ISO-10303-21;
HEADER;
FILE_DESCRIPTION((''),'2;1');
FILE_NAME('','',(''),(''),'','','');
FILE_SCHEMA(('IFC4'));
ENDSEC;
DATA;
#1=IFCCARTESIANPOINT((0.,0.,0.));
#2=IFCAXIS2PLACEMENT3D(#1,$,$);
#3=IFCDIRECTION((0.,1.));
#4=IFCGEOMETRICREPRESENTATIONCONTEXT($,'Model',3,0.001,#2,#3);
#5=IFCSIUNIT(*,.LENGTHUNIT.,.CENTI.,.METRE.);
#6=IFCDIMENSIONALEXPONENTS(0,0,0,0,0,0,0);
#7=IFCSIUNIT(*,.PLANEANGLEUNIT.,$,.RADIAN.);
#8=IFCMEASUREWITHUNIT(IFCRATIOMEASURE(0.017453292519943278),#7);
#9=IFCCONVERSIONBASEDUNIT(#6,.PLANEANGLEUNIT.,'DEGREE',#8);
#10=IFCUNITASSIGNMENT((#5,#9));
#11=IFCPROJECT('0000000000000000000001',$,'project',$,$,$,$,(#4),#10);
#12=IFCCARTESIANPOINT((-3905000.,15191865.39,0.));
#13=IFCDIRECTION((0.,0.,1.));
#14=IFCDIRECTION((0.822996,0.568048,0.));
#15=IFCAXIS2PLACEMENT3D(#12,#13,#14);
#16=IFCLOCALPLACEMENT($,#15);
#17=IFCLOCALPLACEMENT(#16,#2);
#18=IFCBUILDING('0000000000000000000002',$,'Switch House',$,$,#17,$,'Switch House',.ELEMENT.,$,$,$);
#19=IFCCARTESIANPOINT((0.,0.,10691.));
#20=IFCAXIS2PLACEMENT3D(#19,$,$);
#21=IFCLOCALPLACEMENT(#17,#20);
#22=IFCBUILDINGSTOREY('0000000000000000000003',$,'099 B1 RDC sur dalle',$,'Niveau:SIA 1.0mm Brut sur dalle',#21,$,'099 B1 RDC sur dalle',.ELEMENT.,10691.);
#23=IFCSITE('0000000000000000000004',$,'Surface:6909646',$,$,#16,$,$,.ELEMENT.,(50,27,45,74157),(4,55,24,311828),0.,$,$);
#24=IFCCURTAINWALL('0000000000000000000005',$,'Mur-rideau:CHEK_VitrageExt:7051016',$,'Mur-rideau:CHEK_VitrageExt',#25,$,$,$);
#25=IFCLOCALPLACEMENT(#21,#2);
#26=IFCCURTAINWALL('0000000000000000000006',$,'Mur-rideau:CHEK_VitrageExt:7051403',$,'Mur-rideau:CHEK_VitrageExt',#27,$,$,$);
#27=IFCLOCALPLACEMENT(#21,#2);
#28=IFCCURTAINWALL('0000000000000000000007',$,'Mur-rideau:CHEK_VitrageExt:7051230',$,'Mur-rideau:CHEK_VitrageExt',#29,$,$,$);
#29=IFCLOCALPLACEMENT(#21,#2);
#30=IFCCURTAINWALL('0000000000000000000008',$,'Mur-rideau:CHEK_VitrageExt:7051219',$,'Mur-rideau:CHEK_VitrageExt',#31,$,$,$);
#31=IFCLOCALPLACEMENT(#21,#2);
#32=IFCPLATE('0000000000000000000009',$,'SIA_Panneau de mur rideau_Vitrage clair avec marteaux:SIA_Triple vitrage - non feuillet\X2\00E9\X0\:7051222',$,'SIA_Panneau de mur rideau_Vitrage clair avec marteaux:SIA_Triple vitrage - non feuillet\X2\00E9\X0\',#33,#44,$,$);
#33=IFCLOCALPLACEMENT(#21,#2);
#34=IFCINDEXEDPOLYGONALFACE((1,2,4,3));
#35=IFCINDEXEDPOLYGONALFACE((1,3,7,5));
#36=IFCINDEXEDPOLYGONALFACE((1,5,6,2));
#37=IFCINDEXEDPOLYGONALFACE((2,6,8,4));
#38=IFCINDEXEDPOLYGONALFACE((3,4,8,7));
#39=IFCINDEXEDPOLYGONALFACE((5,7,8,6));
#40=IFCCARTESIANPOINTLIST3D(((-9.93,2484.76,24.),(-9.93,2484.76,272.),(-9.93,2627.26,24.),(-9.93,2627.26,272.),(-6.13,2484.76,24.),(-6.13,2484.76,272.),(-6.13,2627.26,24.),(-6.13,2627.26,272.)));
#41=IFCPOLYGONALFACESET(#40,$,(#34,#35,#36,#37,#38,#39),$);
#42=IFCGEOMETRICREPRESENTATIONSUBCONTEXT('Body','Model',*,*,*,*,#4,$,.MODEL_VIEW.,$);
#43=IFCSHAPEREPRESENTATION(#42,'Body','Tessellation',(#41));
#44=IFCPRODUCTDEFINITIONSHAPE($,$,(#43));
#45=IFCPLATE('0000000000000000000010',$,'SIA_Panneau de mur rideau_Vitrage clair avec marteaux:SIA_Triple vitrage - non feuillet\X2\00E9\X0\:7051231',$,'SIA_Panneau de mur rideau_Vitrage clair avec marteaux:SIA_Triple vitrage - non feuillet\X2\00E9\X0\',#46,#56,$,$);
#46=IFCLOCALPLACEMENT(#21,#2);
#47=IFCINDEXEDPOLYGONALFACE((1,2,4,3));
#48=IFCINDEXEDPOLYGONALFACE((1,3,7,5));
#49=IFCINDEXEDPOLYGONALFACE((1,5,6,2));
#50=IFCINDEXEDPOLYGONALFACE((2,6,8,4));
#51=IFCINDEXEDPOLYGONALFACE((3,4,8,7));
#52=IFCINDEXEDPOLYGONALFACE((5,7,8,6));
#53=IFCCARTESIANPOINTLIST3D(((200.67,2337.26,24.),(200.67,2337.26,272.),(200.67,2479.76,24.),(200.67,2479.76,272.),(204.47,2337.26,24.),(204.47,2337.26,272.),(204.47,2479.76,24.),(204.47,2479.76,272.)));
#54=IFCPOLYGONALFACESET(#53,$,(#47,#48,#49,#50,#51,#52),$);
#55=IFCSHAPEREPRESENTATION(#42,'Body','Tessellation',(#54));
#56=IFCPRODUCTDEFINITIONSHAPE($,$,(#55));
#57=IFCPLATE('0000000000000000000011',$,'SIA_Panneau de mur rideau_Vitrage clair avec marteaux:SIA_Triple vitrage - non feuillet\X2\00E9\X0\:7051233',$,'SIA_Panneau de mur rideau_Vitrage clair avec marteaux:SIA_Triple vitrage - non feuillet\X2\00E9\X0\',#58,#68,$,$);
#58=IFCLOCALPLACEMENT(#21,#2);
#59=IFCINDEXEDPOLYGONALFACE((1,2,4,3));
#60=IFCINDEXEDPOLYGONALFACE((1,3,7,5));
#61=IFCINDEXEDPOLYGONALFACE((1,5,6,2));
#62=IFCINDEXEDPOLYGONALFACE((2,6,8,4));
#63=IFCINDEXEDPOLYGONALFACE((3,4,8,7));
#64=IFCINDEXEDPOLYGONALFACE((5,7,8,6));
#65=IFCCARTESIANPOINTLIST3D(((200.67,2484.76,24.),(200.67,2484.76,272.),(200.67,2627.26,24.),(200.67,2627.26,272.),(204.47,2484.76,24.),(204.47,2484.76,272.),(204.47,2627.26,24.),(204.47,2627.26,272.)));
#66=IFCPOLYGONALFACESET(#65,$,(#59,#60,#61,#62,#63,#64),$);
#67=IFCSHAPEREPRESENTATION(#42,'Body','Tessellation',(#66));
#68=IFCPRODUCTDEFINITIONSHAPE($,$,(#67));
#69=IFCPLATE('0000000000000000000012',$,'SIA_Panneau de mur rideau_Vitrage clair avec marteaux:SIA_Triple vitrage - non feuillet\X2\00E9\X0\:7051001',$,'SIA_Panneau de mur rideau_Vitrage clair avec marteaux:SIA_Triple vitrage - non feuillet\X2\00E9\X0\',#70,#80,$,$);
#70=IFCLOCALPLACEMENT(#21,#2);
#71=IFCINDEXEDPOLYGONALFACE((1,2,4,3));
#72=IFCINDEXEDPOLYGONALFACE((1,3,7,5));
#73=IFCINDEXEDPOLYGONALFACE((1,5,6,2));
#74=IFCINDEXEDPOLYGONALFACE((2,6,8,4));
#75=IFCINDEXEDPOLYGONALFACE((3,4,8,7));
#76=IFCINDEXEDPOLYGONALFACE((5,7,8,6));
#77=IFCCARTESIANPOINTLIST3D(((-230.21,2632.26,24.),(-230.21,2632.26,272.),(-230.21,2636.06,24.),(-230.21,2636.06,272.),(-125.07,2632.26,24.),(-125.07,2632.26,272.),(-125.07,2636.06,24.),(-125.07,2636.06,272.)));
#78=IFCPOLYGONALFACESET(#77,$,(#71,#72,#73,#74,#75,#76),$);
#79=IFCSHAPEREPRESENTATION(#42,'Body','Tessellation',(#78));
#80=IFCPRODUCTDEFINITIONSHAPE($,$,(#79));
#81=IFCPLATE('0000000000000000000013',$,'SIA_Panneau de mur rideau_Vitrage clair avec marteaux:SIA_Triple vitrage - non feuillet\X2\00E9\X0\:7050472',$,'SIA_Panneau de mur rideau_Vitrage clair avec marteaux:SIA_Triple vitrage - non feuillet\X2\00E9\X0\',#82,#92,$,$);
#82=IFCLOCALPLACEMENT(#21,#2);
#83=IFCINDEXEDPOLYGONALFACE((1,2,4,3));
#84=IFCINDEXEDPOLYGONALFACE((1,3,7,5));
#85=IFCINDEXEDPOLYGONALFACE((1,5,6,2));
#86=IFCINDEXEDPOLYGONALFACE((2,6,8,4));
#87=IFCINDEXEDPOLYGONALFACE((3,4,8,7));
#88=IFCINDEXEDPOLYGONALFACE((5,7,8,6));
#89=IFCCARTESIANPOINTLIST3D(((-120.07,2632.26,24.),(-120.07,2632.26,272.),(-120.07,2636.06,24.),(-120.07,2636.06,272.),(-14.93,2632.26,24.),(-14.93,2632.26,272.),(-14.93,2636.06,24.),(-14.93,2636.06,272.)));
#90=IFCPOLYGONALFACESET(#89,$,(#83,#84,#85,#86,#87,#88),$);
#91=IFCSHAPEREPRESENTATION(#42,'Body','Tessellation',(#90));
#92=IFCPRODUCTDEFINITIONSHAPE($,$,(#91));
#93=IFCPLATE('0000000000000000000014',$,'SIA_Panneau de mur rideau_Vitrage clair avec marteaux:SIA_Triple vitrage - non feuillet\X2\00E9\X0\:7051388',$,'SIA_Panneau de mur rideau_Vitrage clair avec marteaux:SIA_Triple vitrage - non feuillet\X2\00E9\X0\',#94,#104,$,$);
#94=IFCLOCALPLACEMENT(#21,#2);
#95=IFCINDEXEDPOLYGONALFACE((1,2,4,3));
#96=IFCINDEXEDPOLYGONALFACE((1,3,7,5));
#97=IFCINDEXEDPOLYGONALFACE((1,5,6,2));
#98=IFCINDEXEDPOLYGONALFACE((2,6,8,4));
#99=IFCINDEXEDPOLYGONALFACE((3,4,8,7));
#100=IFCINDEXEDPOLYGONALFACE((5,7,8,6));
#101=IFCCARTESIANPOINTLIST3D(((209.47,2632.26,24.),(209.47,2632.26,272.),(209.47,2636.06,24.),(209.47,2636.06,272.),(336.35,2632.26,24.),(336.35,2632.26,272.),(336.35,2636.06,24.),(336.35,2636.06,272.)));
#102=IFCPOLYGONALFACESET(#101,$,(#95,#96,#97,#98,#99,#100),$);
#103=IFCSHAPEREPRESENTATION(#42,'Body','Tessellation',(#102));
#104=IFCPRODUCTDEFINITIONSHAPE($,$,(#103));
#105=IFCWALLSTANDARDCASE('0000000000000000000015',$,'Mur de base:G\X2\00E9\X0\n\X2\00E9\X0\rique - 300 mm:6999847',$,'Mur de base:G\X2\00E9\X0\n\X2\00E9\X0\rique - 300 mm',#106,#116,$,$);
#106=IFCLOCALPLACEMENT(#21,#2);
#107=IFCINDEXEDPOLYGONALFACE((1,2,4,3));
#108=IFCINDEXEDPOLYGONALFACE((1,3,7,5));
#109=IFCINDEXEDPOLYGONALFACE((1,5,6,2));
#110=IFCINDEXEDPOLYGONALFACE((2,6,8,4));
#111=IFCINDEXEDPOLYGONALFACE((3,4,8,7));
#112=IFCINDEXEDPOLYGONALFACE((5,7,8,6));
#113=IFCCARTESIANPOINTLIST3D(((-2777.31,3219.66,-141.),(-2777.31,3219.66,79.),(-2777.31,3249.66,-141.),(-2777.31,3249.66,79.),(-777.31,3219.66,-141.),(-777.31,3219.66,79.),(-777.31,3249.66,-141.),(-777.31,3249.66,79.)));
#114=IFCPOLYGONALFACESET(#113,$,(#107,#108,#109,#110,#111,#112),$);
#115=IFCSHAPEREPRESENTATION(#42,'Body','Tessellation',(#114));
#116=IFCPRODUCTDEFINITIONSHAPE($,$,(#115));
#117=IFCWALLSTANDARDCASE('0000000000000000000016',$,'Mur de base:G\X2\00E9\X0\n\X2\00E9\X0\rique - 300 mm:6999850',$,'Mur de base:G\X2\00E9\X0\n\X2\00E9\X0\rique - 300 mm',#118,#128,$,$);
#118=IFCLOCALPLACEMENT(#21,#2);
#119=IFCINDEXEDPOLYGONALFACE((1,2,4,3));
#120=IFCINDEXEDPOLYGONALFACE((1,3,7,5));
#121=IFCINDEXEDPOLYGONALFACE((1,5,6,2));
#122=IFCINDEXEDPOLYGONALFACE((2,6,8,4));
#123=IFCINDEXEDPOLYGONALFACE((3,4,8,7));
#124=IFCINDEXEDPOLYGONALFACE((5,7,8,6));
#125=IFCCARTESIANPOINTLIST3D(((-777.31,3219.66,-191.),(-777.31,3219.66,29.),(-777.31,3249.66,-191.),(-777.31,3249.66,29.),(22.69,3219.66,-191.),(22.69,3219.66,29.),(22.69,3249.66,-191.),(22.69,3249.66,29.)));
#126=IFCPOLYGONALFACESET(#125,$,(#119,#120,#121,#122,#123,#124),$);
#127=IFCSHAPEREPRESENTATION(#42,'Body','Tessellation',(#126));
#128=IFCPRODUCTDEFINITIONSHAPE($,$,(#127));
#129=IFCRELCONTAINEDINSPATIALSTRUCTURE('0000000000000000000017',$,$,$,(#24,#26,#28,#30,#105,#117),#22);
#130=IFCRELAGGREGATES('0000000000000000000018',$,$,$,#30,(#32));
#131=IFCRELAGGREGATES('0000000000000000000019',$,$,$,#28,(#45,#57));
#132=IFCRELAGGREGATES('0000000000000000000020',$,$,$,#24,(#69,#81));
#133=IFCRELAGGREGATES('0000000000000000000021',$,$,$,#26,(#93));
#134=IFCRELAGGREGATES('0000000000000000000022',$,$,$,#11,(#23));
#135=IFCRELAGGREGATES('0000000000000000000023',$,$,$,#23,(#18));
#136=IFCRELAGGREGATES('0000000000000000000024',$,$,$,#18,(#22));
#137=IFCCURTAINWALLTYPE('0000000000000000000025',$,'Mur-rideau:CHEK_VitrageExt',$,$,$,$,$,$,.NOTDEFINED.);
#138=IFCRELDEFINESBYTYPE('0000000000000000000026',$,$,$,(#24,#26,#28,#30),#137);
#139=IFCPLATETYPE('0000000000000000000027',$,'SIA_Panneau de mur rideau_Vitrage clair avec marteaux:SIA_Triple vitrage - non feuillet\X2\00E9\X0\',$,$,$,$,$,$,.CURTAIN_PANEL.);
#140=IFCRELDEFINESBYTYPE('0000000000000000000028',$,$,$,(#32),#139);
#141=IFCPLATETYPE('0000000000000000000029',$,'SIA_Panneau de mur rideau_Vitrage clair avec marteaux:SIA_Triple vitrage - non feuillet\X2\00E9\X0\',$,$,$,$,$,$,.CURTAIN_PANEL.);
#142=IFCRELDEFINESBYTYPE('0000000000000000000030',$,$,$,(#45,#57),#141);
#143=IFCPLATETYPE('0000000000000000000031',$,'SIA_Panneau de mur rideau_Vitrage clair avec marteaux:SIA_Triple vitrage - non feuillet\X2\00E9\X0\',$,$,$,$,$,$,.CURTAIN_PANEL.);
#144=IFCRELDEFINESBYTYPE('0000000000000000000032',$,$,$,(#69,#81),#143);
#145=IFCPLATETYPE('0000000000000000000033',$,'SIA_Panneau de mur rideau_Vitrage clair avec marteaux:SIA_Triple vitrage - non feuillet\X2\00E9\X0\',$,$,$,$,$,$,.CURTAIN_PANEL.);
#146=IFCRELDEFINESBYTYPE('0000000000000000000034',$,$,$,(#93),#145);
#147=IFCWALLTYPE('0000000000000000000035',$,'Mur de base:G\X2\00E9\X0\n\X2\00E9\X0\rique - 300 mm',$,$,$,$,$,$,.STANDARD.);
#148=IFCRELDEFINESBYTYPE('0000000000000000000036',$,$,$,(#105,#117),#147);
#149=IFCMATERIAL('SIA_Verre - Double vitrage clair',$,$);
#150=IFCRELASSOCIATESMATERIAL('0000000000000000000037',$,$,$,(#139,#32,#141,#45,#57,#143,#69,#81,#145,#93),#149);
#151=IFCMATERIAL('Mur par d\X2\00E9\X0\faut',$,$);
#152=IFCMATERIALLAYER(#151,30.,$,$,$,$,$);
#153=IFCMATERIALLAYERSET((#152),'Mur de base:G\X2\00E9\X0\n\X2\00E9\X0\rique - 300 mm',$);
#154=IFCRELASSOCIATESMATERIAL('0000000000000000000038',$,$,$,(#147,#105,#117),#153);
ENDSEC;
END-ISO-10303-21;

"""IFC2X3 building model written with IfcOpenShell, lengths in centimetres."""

from ifc_helpers import new_model, entity, si_unit, converted_unit, direction, frame, frame_2d, origin, origin_2d_with_axis, place, context, subcontext, project, spatial, rectangle, extrude, source, transform, mapped, material, layer, layer_set, layer_usage, type_object, type_shapes, element, aggregate, save


model = new_model("IFC2X3")

# Units and contexts
model_context = context("Model", 3, precision=0.001, world=origin(), true_north=direction((0.0, 1.0)))
body_context = subcontext(model_context, "Body", "Model", "MODEL_VIEW")
ifc_project = project(units=[si_unit("LENGTHUNIT", "METRE", prefix="CENTI"), converted_unit("PLANEANGLEUNIT", "DEGREE", entity("IfcRatioMeasure", 0.017453292519943278), si_unit("PLANEANGLEUNIT", "RADIAN"), dimensions=[0, 0, 0, 0, 0, 0, 0])], contexts=[model_context])

# Site, building, storey
site_placement = place(None, frame((-3905000.0, 15191865.39, 0.0), z_axis=(0.0, 0.0, 1.0), x_axis=(0.822996, 0.568048, 0.0)))
site = spatial("IfcSite", under=ifc_project, at=site_placement, Name="Surface:6909646", CompositionType="ELEMENT", RefLatitude=(50, 27, 45, 74157), RefLongitude=(4, 55, 24, 311828), RefElevation=0.0)
building_placement = place(site_placement, origin())
building = spatial("IfcBuilding", under=site, at=building_placement, Name="Switch House", LongName="Switch House", CompositionType="ELEMENT")
storey_placement = place(building_placement, frame((0.0, 0.0, 10691.0)))
storey = spatial("IfcBuildingStorey", under=building, at=storey_placement, Name="099 B1 RDC sur dalle", ObjectType="Niveau:SIA 1.0mm Brut sur dalle", LongName="099 B1 RDC sur dalle", CompositionType="ELEMENT", Elevation=10691.0)

# Curtain walls
curtain_wall_type = type_object("IfcCurtainWallType", Name="Mur-rideau:CHEK_VitrageExt", PredefinedType="NOTDEFINED")
curtain_wall_1_placement = place(storey_placement, frame((0.0, 0.0, -10691.0)))
curtain_wall_1 = element("IfcCurtainWall", 1, at=curtain_wall_1_placement, inside=storey, type_object=curtain_wall_type, Name="Mur-rideau:CHEK_VitrageExt:7051016", ObjectType="Mur-rideau:CHEK_VitrageExt")
curtain_wall_2_placement = place(storey_placement, frame((0.0, 0.0, -10691.0)))
curtain_wall_2 = element("IfcCurtainWall", 2, at=curtain_wall_2_placement, inside=storey, type_object=curtain_wall_type, Name="Mur-rideau:CHEK_VitrageExt:7051403", ObjectType="Mur-rideau:CHEK_VitrageExt")

# Curtain wall
curtain_wall_3_placement = place(storey_placement, frame((0.0, 0.0, -10691.0)))
curtain_wall_3 = element("IfcCurtainWall", 3, at=curtain_wall_3_placement, inside=storey, type_object=curtain_wall_type, Name="Mur-rideau:CHEK_VitrageExt:7051230", ObjectType="Mur-rideau:CHEK_VitrageExt")

# Curtain wall
curtain_wall_4_placement = place(storey_placement, frame((0.0, 0.0, -10691.0)))
curtain_wall_4 = element("IfcCurtainWall", 4, at=curtain_wall_4_placement, inside=storey, type_object=curtain_wall_type, Name="Mur-rideau:CHEK_VitrageExt:7051219", ObjectType="Mur-rideau:CHEK_VitrageExt")

# Plates
ifc_material_1 = material(Name="SIA_Verre - Double vitrage clair")
plate_type_1 = type_object("IfcPlateType", Name="SIA_Panneau de mur rideau_Vitrage clair avec marteaux:SIA_Triple vitrage - non feuilleté", PredefinedType="CURTAIN_PANEL", material=ifc_material_1)
shared_shape_1 = source(origin(), body_context, "Body", "SweptSolid", [
    extrude(rectangle(XDim=3.8, YDim=142.5, at=origin_2d_with_axis()), frame((0.0, -1.9, 0.0), z_axis=(0.0, 0.0, 1.0), x_axis=(0.0, 1.0, 0.0)), (0.0, 0.0, 1.0), 248.0),
])
type_shapes(plate_type_1, [shared_shape_1])
plate_1_placement = place(curtain_wall_4_placement, frame((-9.93, 2556.01, 10715.0), z_axis=(0.0, 0.0, 1.0), x_axis=(0.0, 1.0, 0.0)))
plate_1 = element("IfcPlate", 5, at=plate_1_placement, type_object=plate_type_1, material=ifc_material_1, Name="SIA_Panneau de mur rideau_Vitrage clair avec marteaux:SIA_Triple vitrage - non feuilleté:7051222", ObjectType="SIA_Panneau de mur rideau_Vitrage clair avec marteaux:SIA_Triple vitrage - non feuilleté", context=body_context, shape_type="MappedRepresentation", body=[
    mapped(shared_shape_1, transform((0.0, 0.0, 0.0), scale=1.0)),
])
aggregate(curtain_wall_4, [plate_1])
plate_type_2 = type_object("IfcPlateType", Name="SIA_Panneau de mur rideau_Vitrage clair avec marteaux:SIA_Triple vitrage - non feuilleté", PredefinedType="CURTAIN_PANEL", material=ifc_material_1)
shared_shape_2 = source(origin(), body_context, "Body", "SweptSolid", [
    extrude(rectangle(XDim=142.5, YDim=3.8, at=origin_2d_with_axis()), frame((0.0, 1.9, 0.0), z_axis=(0.0, 0.0, 1.0), x_axis=(-1.0, 0.0, 0.0)), (0.0, 0.0, 1.0), 248.0),
])
type_shapes(plate_type_2, [shared_shape_2])
plate_2_placement = place(curtain_wall_3_placement, frame((204.47, 2408.51, 10715.0), z_axis=(0.0, 0.0, 1.0), x_axis=(0.0, 1.0, 0.0)))
plate_2 = element("IfcPlate", 6, at=plate_2_placement, type_object=plate_type_2, material=ifc_material_1, Name="SIA_Panneau de mur rideau_Vitrage clair avec marteaux:SIA_Triple vitrage - non feuilleté:7051231", ObjectType="SIA_Panneau de mur rideau_Vitrage clair avec marteaux:SIA_Triple vitrage - non feuilleté", context=body_context, shape_type="MappedRepresentation", body=[
    mapped(shared_shape_2, transform((0.0, 0.0, 0.0), scale=1.0)),
])
plate_3_placement = place(curtain_wall_3_placement, frame((204.47, 2556.01, 10715.0), z_axis=(0.0, 0.0, 1.0), x_axis=(0.0, 1.0, 0.0)))
plate_3 = element("IfcPlate", 7, at=plate_3_placement, type_object=plate_type_2, material=ifc_material_1, Name="SIA_Panneau de mur rideau_Vitrage clair avec marteaux:SIA_Triple vitrage - non feuilleté:7051233", ObjectType="SIA_Panneau de mur rideau_Vitrage clair avec marteaux:SIA_Triple vitrage - non feuilleté", context=body_context, shape_type="MappedRepresentation", body=[
    mapped(shared_shape_2, transform((0.0, 0.0, 0.0), scale=1.0)),
])
aggregate(curtain_wall_3, [plate_2, plate_3])
plate_type_3 = type_object("IfcPlateType", Name="SIA_Panneau de mur rideau_Vitrage clair avec marteaux:SIA_Triple vitrage - non feuilleté", PredefinedType="CURTAIN_PANEL", material=ifc_material_1)
shared_shape_3 = source(origin(), body_context, "Body", "SweptSolid", [
    extrude(rectangle(XDim=105.14, YDim=3.8, at=origin_2d_with_axis()), frame((0.0, 1.9, 0.0), z_axis=(0.0, 0.0, 1.0), x_axis=(-1.0, 0.0, 0.0)), (0.0, 0.0, 1.0), 248.0),
])
type_shapes(plate_type_3, [shared_shape_3])
plate_4_placement = place(curtain_wall_1_placement, frame((-177.64, 2632.26, 10715.0)))
plate_4 = element("IfcPlate", 8, at=plate_4_placement, type_object=plate_type_3, material=ifc_material_1, Name="SIA_Panneau de mur rideau_Vitrage clair avec marteaux:SIA_Triple vitrage - non feuilleté:7051001", ObjectType="SIA_Panneau de mur rideau_Vitrage clair avec marteaux:SIA_Triple vitrage - non feuilleté", context=body_context, shape_type="MappedRepresentation", body=[
    mapped(shared_shape_3, transform((0.0, 0.0, 0.0), scale=1.0)),
])
plate_5_placement = place(curtain_wall_1_placement, frame((-67.5, 2632.26, 10715.0)))
plate_5 = element("IfcPlate", 9, at=plate_5_placement, type_object=plate_type_3, material=ifc_material_1, Name="SIA_Panneau de mur rideau_Vitrage clair avec marteaux:SIA_Triple vitrage - non feuilleté:7050472", ObjectType="SIA_Panneau de mur rideau_Vitrage clair avec marteaux:SIA_Triple vitrage - non feuilleté", context=body_context, shape_type="MappedRepresentation", body=[
    mapped(shared_shape_3, transform((0.0, 0.0, 0.0), scale=1.0)),
])
aggregate(curtain_wall_1, [plate_4, plate_5])
plate_type_4 = type_object("IfcPlateType", Name="SIA_Panneau de mur rideau_Vitrage clair avec marteaux:SIA_Triple vitrage - non feuilleté", PredefinedType="CURTAIN_PANEL", material=ifc_material_1)
shared_shape_4 = source(origin(), body_context, "Body", "SweptSolid", [
    extrude(rectangle(XDim=126.88, YDim=3.8, at=origin_2d_with_axis()), frame((0.0, 1.9, 0.0), z_axis=(0.0, 0.0, 1.0), x_axis=(-1.0, 0.0, 0.0)), (0.0, 0.0, 1.0), 248.0),
])
type_shapes(plate_type_4, [shared_shape_4])
plate_6_placement = place(curtain_wall_2_placement, frame((272.91, 2632.26, 10715.0)))
plate_6 = element("IfcPlate", 10, at=plate_6_placement, type_object=plate_type_4, material=ifc_material_1, Name="SIA_Panneau de mur rideau_Vitrage clair avec marteaux:SIA_Triple vitrage - non feuilleté:7051388", ObjectType="SIA_Panneau de mur rideau_Vitrage clair avec marteaux:SIA_Triple vitrage - non feuilleté", context=body_context, shape_type="MappedRepresentation", body=[
    mapped(shared_shape_4, transform((0.0, 0.0, 0.0), scale=1.0)),
])
aggregate(curtain_wall_2, [plate_6])

# Walls
ifc_material_2 = material(Name="Mur par défaut")
ifc_layer = layer(ifc_material_2, 30.0)
ifc_layer_set = layer_set([ifc_layer], Name="Mur de base:Générique - 300 mm")
ifc_layer_usage_1 = layer_usage(ifc_layer_set, "AXIS2", "POSITIVE", -15.0)
wall_type = type_object("IfcWallType", Name="Mur de base:Générique - 300 mm", PredefinedType="STANDARD", material=ifc_layer_set)
wall_1_placement = place(storey_placement, frame((-777.31, 3234.66, -141.0), z_axis=(0.0, 0.0, 1.0), x_axis=(-1.0, 0.0, 0.0)))
element("IfcWallStandardCase", 11, at=wall_1_placement, inside=storey, type_object=wall_type, material=ifc_layer_usage_1, Name="Mur de base:Générique - 300 mm:6999847", ObjectType="Mur de base:Générique - 300 mm", context=body_context, shape_type="SweptSolid", body=[
    extrude(rectangle(XDim=2000.0, YDim=30.0, at=frame_2d((1000.0, 0.0), x_axis=(-1.0, 0.0))), origin(), (0.0, 0.0, 1.0), 220.0),
])
ifc_layer_usage_2 = layer_usage(ifc_layer_set, "AXIS2", "NEGATIVE", 15.0)
wall_2_placement = place(storey_placement, frame((22.69, 3234.66, -191.0), z_axis=(0.0, 0.0, 1.0), x_axis=(-1.0, 0.0, 0.0)))
element("IfcWallStandardCase", 12, at=wall_2_placement, inside=storey, type_object=wall_type, material=ifc_layer_usage_2, Name="Mur de base:Générique - 300 mm:6999850", ObjectType="Mur de base:Générique - 300 mm", context=body_context, shape_type="SweptSolid", body=[
    extrude(rectangle(XDim=800.0, YDim=30.0, at=frame_2d((400.0, 0.0), x_axis=(-1.0, 0.0))), origin(), (0.0, 0.0, 1.0), 220.0),
])

save(model, "model.ifc")
